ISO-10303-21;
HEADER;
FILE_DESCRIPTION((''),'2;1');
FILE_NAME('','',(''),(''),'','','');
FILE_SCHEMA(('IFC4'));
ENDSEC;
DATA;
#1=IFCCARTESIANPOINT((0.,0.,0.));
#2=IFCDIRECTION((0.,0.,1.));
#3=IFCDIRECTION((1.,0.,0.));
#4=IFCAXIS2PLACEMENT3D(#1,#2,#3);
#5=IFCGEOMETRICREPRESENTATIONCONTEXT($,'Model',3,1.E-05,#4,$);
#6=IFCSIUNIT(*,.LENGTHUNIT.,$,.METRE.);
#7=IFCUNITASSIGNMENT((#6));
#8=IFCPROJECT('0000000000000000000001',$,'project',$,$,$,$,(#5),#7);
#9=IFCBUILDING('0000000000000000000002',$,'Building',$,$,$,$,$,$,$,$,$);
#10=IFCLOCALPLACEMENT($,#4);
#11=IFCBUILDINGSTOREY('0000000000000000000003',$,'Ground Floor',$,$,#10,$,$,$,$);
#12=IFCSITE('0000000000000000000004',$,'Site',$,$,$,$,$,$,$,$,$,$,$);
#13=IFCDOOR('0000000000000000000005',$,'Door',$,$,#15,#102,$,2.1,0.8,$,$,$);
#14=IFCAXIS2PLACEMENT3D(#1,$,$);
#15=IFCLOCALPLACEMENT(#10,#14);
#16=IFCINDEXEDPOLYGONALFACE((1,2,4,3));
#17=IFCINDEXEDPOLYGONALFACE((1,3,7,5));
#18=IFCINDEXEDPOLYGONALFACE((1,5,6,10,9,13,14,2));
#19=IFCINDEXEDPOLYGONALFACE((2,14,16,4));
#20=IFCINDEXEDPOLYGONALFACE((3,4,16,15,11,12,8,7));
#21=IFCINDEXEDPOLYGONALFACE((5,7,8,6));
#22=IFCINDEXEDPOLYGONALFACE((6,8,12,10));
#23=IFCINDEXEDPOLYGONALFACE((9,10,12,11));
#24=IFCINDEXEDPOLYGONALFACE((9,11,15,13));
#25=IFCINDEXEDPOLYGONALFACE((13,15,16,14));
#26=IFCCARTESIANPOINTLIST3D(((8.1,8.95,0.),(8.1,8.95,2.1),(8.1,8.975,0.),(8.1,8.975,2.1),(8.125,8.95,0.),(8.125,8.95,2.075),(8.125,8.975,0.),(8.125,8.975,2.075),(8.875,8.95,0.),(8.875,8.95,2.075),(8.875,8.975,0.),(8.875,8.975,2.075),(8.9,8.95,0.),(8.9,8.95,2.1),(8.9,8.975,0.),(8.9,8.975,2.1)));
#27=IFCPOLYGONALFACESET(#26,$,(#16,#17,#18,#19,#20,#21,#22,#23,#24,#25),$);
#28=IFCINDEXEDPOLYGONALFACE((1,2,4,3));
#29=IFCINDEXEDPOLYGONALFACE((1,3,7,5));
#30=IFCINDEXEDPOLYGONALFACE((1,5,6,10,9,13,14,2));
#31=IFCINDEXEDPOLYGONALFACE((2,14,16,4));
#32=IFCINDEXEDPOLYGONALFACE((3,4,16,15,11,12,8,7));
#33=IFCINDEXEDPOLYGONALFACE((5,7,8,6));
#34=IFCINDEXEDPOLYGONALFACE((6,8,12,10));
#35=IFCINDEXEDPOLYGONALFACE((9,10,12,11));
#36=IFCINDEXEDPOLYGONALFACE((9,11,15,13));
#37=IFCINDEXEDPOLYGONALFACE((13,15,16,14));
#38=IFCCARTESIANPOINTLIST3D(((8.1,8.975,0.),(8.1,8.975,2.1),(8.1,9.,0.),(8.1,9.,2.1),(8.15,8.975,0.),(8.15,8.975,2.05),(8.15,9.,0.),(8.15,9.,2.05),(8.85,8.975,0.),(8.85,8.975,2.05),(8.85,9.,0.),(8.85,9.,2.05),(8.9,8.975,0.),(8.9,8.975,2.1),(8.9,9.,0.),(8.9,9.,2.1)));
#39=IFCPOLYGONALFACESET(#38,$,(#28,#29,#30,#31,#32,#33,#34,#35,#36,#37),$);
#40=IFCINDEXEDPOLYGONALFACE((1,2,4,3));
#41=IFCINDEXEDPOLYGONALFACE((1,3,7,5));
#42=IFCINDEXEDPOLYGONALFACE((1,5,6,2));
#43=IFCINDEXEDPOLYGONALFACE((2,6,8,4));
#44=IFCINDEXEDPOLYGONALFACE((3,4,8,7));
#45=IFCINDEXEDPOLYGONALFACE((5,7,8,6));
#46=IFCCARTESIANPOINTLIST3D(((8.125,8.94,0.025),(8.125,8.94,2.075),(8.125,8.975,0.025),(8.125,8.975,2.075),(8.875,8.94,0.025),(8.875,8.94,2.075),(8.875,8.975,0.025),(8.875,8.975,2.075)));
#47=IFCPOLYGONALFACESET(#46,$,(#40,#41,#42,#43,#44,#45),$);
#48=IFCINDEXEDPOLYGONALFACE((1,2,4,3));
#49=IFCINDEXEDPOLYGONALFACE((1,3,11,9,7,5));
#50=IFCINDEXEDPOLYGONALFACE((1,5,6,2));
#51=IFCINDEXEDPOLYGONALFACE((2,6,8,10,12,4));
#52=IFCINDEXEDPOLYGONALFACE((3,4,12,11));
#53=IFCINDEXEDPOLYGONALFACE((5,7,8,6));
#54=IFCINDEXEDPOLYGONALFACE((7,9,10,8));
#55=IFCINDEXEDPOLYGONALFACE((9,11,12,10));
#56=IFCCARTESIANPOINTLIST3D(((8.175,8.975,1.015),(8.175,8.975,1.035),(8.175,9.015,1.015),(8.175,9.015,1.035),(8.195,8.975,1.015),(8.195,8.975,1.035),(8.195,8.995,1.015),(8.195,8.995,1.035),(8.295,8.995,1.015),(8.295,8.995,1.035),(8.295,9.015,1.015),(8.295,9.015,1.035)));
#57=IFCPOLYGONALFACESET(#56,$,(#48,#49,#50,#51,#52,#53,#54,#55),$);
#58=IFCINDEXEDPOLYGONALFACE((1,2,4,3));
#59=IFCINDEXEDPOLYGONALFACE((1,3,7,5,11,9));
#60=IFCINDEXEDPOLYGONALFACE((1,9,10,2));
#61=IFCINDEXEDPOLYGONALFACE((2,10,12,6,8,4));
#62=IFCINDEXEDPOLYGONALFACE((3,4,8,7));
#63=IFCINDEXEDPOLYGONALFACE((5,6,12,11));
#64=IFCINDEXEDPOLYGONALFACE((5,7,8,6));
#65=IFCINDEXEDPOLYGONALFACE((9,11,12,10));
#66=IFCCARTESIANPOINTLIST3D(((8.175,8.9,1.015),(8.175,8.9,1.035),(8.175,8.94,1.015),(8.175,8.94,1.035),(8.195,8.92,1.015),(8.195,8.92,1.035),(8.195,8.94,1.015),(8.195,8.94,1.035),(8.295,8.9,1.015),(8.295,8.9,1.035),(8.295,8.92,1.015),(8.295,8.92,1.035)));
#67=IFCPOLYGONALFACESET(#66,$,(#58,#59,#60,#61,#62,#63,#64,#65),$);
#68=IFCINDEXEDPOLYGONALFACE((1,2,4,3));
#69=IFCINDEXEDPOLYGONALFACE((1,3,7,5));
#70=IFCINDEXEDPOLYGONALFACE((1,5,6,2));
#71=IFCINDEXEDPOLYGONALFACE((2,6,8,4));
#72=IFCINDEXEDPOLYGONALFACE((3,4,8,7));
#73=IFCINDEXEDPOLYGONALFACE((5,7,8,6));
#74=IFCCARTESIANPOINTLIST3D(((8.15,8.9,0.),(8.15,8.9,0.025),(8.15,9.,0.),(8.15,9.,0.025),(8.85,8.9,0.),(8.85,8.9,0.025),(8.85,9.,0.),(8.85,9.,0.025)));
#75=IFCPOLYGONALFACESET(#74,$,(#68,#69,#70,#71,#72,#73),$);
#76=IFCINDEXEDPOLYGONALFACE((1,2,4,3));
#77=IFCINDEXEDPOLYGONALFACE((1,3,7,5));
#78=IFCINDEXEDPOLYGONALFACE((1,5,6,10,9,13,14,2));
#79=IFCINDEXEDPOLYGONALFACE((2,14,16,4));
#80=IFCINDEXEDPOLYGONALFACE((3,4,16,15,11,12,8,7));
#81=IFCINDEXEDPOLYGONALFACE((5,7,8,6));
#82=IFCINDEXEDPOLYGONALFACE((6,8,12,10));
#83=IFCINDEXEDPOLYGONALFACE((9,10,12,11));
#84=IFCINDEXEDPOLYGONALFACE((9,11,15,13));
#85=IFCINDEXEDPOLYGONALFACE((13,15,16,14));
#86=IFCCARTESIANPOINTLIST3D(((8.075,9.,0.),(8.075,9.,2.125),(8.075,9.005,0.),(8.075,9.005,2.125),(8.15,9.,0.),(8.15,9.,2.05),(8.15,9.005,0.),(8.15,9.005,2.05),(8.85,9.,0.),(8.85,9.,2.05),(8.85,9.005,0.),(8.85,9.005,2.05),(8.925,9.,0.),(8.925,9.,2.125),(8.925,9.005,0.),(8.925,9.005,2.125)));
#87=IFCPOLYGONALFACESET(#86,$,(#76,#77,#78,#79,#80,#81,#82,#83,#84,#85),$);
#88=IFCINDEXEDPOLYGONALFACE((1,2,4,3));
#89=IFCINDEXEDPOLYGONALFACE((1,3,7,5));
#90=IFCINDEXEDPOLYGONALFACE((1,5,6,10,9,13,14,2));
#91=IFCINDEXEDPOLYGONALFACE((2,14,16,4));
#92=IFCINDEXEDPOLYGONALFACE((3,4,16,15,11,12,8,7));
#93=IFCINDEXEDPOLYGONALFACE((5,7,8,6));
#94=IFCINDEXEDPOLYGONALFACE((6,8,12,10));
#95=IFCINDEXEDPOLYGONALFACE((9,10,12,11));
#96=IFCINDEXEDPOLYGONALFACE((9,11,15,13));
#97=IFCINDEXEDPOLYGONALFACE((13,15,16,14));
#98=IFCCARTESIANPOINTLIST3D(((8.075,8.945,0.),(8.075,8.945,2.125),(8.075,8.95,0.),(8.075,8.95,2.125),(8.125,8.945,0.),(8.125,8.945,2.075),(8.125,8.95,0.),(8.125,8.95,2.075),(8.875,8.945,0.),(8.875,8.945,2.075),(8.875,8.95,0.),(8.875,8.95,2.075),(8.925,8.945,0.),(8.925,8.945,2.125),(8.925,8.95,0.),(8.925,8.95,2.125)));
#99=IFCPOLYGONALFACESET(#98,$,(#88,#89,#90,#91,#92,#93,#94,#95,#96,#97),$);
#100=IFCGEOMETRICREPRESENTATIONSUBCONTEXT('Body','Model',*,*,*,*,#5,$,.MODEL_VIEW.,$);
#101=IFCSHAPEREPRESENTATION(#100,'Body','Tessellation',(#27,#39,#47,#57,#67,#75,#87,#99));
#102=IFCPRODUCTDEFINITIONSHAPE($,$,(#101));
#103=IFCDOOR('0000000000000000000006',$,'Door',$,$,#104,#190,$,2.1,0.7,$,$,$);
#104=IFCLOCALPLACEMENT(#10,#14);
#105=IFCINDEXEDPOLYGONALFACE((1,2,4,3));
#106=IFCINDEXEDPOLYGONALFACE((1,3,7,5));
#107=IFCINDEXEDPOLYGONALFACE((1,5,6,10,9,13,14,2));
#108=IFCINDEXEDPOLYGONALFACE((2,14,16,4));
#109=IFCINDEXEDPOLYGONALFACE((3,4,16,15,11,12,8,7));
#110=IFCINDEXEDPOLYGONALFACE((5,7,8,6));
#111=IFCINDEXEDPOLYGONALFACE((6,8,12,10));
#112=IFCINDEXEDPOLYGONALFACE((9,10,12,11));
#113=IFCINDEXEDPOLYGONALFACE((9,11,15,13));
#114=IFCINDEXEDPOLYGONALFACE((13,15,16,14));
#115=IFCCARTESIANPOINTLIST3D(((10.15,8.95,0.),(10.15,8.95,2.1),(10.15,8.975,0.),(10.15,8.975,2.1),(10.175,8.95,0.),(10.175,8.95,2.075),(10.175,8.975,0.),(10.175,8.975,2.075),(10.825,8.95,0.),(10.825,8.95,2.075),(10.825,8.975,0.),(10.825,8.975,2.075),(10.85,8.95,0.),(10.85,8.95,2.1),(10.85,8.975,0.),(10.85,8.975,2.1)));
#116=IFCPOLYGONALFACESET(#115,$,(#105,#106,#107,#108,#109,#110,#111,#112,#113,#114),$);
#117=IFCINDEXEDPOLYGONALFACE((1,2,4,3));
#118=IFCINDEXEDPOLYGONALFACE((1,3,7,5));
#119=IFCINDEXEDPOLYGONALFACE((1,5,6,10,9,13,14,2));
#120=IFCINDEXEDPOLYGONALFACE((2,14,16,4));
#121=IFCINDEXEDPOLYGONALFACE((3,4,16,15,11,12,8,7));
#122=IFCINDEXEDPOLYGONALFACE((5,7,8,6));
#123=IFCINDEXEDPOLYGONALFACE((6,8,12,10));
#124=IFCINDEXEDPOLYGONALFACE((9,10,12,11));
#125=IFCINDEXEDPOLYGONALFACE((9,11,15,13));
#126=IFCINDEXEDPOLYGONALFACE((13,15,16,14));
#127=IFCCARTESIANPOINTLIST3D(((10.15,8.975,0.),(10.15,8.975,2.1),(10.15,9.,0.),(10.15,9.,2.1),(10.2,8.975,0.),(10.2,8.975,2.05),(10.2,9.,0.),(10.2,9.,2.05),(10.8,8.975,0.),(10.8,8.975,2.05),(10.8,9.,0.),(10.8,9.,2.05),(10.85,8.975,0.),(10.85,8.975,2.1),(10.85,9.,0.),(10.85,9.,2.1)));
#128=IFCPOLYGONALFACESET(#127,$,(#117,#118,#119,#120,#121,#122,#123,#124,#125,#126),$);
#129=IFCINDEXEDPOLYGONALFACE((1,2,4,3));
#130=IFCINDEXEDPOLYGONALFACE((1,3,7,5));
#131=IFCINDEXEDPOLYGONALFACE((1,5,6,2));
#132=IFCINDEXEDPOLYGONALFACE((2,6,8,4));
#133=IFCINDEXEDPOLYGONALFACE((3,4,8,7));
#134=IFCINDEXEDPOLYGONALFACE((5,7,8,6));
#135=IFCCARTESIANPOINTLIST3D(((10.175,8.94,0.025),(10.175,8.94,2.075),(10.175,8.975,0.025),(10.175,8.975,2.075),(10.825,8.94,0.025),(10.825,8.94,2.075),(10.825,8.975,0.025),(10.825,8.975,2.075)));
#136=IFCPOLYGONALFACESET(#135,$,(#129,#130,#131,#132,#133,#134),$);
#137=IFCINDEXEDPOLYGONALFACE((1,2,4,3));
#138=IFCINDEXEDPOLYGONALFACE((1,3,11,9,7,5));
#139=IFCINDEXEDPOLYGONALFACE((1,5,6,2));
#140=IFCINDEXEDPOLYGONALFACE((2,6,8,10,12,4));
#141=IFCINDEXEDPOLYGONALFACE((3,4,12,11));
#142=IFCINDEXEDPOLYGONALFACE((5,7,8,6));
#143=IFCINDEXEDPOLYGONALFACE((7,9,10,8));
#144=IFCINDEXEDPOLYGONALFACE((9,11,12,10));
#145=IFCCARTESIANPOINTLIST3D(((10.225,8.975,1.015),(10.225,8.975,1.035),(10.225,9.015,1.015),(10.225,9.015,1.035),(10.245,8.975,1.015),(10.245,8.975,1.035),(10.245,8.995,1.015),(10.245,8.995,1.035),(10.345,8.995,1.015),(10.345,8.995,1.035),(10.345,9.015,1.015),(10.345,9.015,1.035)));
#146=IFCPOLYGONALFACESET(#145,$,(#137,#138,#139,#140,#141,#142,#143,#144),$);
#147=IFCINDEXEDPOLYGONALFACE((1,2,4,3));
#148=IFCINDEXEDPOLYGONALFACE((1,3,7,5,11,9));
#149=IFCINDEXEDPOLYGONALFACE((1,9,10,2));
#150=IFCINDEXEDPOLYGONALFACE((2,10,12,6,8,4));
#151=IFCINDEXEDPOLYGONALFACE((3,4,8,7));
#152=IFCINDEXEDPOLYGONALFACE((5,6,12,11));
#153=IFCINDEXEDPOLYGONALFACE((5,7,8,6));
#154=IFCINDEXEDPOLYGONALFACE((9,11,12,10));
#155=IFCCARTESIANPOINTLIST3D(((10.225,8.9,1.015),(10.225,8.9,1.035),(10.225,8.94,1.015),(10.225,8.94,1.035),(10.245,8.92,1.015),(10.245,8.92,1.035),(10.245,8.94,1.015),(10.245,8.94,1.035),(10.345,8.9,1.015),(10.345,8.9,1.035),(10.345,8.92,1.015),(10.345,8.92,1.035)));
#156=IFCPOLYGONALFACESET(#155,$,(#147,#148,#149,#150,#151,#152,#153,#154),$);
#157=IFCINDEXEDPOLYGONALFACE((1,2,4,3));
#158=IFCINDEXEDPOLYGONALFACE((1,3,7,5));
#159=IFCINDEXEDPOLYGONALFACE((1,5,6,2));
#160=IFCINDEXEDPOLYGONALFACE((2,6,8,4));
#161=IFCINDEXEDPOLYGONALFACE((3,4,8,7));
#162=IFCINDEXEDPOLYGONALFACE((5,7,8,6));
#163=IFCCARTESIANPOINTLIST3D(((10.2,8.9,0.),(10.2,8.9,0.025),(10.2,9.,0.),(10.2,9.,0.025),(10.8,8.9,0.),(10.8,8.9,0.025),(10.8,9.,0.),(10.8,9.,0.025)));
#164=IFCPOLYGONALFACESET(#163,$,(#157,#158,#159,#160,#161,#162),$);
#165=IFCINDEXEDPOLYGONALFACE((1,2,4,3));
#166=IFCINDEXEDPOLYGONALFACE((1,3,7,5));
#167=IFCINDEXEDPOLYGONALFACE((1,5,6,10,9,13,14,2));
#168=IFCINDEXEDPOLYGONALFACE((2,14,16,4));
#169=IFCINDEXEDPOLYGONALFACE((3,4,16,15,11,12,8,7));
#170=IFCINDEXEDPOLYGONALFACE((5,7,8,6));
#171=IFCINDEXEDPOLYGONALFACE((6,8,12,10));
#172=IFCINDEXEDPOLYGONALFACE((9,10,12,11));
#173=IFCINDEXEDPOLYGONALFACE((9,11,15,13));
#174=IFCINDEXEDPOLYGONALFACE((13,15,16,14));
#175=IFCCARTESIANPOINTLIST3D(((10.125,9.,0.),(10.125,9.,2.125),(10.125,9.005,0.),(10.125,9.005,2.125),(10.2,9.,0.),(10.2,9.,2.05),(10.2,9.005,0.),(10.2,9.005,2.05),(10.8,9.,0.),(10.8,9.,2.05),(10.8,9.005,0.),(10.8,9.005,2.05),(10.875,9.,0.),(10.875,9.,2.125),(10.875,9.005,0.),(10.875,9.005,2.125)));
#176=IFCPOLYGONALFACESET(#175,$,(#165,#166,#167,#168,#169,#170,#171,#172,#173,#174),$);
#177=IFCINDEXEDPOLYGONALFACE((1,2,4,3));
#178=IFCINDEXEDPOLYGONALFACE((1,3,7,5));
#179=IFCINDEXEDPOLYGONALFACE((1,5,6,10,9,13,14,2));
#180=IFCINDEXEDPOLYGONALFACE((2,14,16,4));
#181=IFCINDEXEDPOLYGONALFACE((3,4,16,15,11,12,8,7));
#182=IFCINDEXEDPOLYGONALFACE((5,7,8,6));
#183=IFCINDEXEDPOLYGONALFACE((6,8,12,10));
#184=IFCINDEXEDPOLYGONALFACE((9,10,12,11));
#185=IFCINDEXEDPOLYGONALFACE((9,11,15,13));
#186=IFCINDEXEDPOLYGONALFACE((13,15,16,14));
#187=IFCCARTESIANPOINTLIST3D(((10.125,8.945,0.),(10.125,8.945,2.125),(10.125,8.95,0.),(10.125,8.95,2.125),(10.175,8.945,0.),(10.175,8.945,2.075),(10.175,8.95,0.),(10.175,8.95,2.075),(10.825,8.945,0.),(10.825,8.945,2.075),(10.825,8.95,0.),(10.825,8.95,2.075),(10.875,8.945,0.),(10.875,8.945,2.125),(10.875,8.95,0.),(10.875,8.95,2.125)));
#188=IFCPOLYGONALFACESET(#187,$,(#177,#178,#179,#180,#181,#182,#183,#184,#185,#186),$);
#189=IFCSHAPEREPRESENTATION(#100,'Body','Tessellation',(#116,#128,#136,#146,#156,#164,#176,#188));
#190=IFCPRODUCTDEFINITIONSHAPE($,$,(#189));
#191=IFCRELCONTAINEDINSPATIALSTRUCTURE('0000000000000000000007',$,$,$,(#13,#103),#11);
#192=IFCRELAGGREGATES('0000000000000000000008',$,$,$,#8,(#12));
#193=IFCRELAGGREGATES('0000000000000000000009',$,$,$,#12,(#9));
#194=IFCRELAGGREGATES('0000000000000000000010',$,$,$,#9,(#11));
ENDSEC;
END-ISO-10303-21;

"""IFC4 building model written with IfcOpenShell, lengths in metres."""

from ifc_helpers import new_model, si_unit, frame, origin_with_axes, place, context, subcontext, project, spatial, line, indexed_curve, outline, extrude, element, save


model = new_model("IFC4")

# Units and contexts
model_context = context("Model", 3, precision=1e-05, world=origin_with_axes())
body_context = subcontext(model_context, "Body", "Model", "MODEL_VIEW")
ifc_project = project(units=[si_unit("LENGTHUNIT", "METRE")], contexts=[model_context])

# Site, building, storey
site = spatial("IfcSite", under=ifc_project, Name="Site")
building = spatial("IfcBuilding", under=site, Name="Building")
storey_placement = place(None, origin_with_axes())
storey = spatial("IfcBuildingStorey", under=building, at=storey_placement, Name="Ground Floor")

# Doors
door_1_placement = place(storey_placement, frame((8.9, 9.0, 0.0), z_axis=(0.0, 0.0, 1.0), x_axis=(-1.0, 0.0, 0.0)))
element("IfcDoor", 1, at=door_1_placement, inside=storey, Name="Door", OverallHeight=2.1, OverallWidth=0.8, context=body_context, shape_type="SweptSolid", body=[
    extrude(outline(indexed_curve([(0.0, 0.0), (0.0, 2.1), (0.8, 2.1), (0.8, 0.0), (0.775, 0.0), (0.775, 2.075), (0.025, 2.075), (0.025, 0.0)], segments=[line(1, 2, 3, 4, 5, 6, 7, 8, 1)])), frame((0.0, 0.025, 0.0), z_axis=(0.0, -1.0, 0.0), x_axis=(1.0, 0.0, 0.0)), (0.0, 0.0, -1.0), 0.025),
    extrude(outline(indexed_curve([(0.0, 0.0), (0.0, 2.1), (0.8, 2.1), (0.8, 0.0), (0.75, 0.0), (0.75, 2.05), (0.05, 2.05), (0.05, 0.0)], segments=[line(1, 2, 3, 4, 5, 6, 7, 8, 1)])), frame((0.0, 0.0, 0.0), z_axis=(0.0, -1.0, 0.0), x_axis=(1.0, 0.0, 0.0)), (0.0, 0.0, -1.0), 0.025),
    extrude(outline(indexed_curve([(0.0, 0.0), (0.75, 0.0), (0.75, 0.035), (0.0, 0.035)], segments=[line(1, 2, 3, 4, 1)])), frame((0.025, 0.025, 0.025), z_axis=(0.0, 0.0, 1.0), x_axis=(1.0, 0.0, 0.0)), (0.0, 0.0, 1.0), 2.05),
    extrude(outline(indexed_curve([(0.0, 0.0), (0.0, -0.04), (-0.12, -0.04), (-0.12, -0.02), (-0.02, -0.02), (-0.02, 0.0)], segments=[line(1, 2, 3, 4, 5, 6, 1)])), frame((0.725, 0.025, 1.015), z_axis=(0.0, 0.0, 1.0), x_axis=(1.0, 0.0, 0.0)), (0.0, 0.0, 1.0), 0.02),
    extrude(outline(indexed_curve([(0.0, 0.0), (0.0, 0.04), (-0.12, 0.04), (-0.12, 0.02), (-0.02, 0.02), (-0.02, 0.0)], segments=[line(1, 2, 3, 4, 5, 6, 1)])), frame((0.725, 0.06, 1.015), z_axis=(0.0, 0.0, 1.0), x_axis=(1.0, 0.0, 0.0)), (0.0, 0.0, 1.0), 0.02),
    extrude(outline(indexed_curve([(0.0, 0.0), (0.7, 0.0), (0.7, 0.1), (0.0, 0.1)], segments=[line(1, 2, 3, 4, 1)])), frame((0.05, 0.0, 0.0), z_axis=(0.0, 0.0, 1.0), x_axis=(1.0, 0.0, 0.0)), (0.0, 0.0, 1.0), 0.025),
    extrude(outline(indexed_curve([(0.0, 0.0), (0.0, 2.125), (0.85, 2.125), (0.85, 0.0), (0.775, 0.0), (0.775, 2.05), (0.075, 2.05), (0.075, 0.0)], segments=[line(1, 2, 3, 4, 5, 6, 7, 8, 1)])), frame((-0.025, -0.005, 0.0), z_axis=(0.0, -1.0, 0.0), x_axis=(1.0, 0.0, 0.0)), (0.0, 0.0, -1.0), 0.005),
    extrude(outline(indexed_curve([(0.0, 0.0), (0.0, 2.125), (0.85, 2.125), (0.85, 0.0), (0.8, 0.0), (0.8, 2.075), (0.05, 2.075), (0.05, 0.0)], segments=[line(1, 2, 3, 4, 5, 6, 7, 8, 1)])), frame((-0.025, 0.05, 0.0), z_axis=(0.0, -1.0, 0.0), x_axis=(1.0, 0.0, 0.0)), (0.0, 0.0, -1.0), 0.005),
])
door_2_placement = place(storey_placement, frame((10.85, 9.0, 0.0), z_axis=(0.0, 0.0, 1.0), x_axis=(-1.0, 0.0, 0.0)))
element("IfcDoor", 2, at=door_2_placement, inside=storey, Name="Door", OverallHeight=2.1, OverallWidth=0.7, context=body_context, shape_type="SweptSolid", body=[
    extrude(outline(indexed_curve([(0.0, 0.0), (0.0, 2.1), (0.7, 2.1), (0.7, 0.0), (0.675, 0.0), (0.675, 2.075), (0.025, 2.075), (0.025, 0.0)], segments=[line(1, 2, 3, 4, 5, 6, 7, 8, 1)])), frame((0.0, 0.025, 0.0), z_axis=(0.0, -1.0, 0.0), x_axis=(1.0, 0.0, 0.0)), (0.0, 0.0, -1.0), 0.025),
    extrude(outline(indexed_curve([(0.0, 0.0), (0.0, 2.1), (0.7, 2.1), (0.7, 0.0), (0.65, 0.0), (0.65, 2.05), (0.05, 2.05), (0.05, 0.0)], segments=[line(1, 2, 3, 4, 5, 6, 7, 8, 1)])), frame((0.0, 0.0, 0.0), z_axis=(0.0, -1.0, 0.0), x_axis=(1.0, 0.0, 0.0)), (0.0, 0.0, -1.0), 0.025),
    extrude(outline(indexed_curve([(0.0, 0.0), (0.65, 0.0), (0.65, 0.035), (0.0, 0.035)], segments=[line(1, 2, 3, 4, 1)])), frame((0.025, 0.025, 0.025), z_axis=(0.0, 0.0, 1.0), x_axis=(1.0, 0.0, 0.0)), (0.0, 0.0, 1.0), 2.05),
    extrude(outline(indexed_curve([(0.0, 0.0), (0.0, -0.04), (-0.12, -0.04), (-0.12, -0.02), (-0.02, -0.02), (-0.02, 0.0)], segments=[line(1, 2, 3, 4, 5, 6, 1)])), frame((0.625, 0.025, 1.015), z_axis=(0.0, 0.0, 1.0), x_axis=(1.0, 0.0, 0.0)), (0.0, 0.0, 1.0), 0.02),
    extrude(outline(indexed_curve([(0.0, 0.0), (0.0, 0.04), (-0.12, 0.04), (-0.12, 0.02), (-0.02, 0.02), (-0.02, 0.0)], segments=[line(1, 2, 3, 4, 5, 6, 1)])), frame((0.625, 0.06, 1.015), z_axis=(0.0, 0.0, 1.0), x_axis=(1.0, 0.0, 0.0)), (0.0, 0.0, 1.0), 0.02),
    extrude(outline(indexed_curve([(0.0, 0.0), (0.6, 0.0), (0.6, 0.1), (0.0, 0.1)], segments=[line(1, 2, 3, 4, 1)])), frame((0.05, 0.0, 0.0), z_axis=(0.0, 0.0, 1.0), x_axis=(1.0, 0.0, 0.0)), (0.0, 0.0, 1.0), 0.025),
    extrude(outline(indexed_curve([(0.0, 0.0), (0.0, 2.125), (0.75, 2.125), (0.75, 0.0), (0.675, 0.0), (0.675, 2.05), (0.075, 2.05), (0.075, 0.0)], segments=[line(1, 2, 3, 4, 5, 6, 7, 8, 1)])), frame((-0.025, -0.005, 0.0), z_axis=(0.0, -1.0, 0.0), x_axis=(1.0, 0.0, 0.0)), (0.0, 0.0, -1.0), 0.005),
    extrude(outline(indexed_curve([(0.0, 0.0), (0.0, 2.125), (0.75, 2.125), (0.75, 0.0), (0.7, 0.0), (0.7, 2.075), (0.05, 2.075), (0.05, 0.0)], segments=[line(1, 2, 3, 4, 5, 6, 7, 8, 1)])), frame((-0.025, 0.05, 0.0), z_axis=(0.0, -1.0, 0.0), x_axis=(1.0, 0.0, 0.0)), (0.0, 0.0, -1.0), 0.005),
])

save(model, "model.ifc")
